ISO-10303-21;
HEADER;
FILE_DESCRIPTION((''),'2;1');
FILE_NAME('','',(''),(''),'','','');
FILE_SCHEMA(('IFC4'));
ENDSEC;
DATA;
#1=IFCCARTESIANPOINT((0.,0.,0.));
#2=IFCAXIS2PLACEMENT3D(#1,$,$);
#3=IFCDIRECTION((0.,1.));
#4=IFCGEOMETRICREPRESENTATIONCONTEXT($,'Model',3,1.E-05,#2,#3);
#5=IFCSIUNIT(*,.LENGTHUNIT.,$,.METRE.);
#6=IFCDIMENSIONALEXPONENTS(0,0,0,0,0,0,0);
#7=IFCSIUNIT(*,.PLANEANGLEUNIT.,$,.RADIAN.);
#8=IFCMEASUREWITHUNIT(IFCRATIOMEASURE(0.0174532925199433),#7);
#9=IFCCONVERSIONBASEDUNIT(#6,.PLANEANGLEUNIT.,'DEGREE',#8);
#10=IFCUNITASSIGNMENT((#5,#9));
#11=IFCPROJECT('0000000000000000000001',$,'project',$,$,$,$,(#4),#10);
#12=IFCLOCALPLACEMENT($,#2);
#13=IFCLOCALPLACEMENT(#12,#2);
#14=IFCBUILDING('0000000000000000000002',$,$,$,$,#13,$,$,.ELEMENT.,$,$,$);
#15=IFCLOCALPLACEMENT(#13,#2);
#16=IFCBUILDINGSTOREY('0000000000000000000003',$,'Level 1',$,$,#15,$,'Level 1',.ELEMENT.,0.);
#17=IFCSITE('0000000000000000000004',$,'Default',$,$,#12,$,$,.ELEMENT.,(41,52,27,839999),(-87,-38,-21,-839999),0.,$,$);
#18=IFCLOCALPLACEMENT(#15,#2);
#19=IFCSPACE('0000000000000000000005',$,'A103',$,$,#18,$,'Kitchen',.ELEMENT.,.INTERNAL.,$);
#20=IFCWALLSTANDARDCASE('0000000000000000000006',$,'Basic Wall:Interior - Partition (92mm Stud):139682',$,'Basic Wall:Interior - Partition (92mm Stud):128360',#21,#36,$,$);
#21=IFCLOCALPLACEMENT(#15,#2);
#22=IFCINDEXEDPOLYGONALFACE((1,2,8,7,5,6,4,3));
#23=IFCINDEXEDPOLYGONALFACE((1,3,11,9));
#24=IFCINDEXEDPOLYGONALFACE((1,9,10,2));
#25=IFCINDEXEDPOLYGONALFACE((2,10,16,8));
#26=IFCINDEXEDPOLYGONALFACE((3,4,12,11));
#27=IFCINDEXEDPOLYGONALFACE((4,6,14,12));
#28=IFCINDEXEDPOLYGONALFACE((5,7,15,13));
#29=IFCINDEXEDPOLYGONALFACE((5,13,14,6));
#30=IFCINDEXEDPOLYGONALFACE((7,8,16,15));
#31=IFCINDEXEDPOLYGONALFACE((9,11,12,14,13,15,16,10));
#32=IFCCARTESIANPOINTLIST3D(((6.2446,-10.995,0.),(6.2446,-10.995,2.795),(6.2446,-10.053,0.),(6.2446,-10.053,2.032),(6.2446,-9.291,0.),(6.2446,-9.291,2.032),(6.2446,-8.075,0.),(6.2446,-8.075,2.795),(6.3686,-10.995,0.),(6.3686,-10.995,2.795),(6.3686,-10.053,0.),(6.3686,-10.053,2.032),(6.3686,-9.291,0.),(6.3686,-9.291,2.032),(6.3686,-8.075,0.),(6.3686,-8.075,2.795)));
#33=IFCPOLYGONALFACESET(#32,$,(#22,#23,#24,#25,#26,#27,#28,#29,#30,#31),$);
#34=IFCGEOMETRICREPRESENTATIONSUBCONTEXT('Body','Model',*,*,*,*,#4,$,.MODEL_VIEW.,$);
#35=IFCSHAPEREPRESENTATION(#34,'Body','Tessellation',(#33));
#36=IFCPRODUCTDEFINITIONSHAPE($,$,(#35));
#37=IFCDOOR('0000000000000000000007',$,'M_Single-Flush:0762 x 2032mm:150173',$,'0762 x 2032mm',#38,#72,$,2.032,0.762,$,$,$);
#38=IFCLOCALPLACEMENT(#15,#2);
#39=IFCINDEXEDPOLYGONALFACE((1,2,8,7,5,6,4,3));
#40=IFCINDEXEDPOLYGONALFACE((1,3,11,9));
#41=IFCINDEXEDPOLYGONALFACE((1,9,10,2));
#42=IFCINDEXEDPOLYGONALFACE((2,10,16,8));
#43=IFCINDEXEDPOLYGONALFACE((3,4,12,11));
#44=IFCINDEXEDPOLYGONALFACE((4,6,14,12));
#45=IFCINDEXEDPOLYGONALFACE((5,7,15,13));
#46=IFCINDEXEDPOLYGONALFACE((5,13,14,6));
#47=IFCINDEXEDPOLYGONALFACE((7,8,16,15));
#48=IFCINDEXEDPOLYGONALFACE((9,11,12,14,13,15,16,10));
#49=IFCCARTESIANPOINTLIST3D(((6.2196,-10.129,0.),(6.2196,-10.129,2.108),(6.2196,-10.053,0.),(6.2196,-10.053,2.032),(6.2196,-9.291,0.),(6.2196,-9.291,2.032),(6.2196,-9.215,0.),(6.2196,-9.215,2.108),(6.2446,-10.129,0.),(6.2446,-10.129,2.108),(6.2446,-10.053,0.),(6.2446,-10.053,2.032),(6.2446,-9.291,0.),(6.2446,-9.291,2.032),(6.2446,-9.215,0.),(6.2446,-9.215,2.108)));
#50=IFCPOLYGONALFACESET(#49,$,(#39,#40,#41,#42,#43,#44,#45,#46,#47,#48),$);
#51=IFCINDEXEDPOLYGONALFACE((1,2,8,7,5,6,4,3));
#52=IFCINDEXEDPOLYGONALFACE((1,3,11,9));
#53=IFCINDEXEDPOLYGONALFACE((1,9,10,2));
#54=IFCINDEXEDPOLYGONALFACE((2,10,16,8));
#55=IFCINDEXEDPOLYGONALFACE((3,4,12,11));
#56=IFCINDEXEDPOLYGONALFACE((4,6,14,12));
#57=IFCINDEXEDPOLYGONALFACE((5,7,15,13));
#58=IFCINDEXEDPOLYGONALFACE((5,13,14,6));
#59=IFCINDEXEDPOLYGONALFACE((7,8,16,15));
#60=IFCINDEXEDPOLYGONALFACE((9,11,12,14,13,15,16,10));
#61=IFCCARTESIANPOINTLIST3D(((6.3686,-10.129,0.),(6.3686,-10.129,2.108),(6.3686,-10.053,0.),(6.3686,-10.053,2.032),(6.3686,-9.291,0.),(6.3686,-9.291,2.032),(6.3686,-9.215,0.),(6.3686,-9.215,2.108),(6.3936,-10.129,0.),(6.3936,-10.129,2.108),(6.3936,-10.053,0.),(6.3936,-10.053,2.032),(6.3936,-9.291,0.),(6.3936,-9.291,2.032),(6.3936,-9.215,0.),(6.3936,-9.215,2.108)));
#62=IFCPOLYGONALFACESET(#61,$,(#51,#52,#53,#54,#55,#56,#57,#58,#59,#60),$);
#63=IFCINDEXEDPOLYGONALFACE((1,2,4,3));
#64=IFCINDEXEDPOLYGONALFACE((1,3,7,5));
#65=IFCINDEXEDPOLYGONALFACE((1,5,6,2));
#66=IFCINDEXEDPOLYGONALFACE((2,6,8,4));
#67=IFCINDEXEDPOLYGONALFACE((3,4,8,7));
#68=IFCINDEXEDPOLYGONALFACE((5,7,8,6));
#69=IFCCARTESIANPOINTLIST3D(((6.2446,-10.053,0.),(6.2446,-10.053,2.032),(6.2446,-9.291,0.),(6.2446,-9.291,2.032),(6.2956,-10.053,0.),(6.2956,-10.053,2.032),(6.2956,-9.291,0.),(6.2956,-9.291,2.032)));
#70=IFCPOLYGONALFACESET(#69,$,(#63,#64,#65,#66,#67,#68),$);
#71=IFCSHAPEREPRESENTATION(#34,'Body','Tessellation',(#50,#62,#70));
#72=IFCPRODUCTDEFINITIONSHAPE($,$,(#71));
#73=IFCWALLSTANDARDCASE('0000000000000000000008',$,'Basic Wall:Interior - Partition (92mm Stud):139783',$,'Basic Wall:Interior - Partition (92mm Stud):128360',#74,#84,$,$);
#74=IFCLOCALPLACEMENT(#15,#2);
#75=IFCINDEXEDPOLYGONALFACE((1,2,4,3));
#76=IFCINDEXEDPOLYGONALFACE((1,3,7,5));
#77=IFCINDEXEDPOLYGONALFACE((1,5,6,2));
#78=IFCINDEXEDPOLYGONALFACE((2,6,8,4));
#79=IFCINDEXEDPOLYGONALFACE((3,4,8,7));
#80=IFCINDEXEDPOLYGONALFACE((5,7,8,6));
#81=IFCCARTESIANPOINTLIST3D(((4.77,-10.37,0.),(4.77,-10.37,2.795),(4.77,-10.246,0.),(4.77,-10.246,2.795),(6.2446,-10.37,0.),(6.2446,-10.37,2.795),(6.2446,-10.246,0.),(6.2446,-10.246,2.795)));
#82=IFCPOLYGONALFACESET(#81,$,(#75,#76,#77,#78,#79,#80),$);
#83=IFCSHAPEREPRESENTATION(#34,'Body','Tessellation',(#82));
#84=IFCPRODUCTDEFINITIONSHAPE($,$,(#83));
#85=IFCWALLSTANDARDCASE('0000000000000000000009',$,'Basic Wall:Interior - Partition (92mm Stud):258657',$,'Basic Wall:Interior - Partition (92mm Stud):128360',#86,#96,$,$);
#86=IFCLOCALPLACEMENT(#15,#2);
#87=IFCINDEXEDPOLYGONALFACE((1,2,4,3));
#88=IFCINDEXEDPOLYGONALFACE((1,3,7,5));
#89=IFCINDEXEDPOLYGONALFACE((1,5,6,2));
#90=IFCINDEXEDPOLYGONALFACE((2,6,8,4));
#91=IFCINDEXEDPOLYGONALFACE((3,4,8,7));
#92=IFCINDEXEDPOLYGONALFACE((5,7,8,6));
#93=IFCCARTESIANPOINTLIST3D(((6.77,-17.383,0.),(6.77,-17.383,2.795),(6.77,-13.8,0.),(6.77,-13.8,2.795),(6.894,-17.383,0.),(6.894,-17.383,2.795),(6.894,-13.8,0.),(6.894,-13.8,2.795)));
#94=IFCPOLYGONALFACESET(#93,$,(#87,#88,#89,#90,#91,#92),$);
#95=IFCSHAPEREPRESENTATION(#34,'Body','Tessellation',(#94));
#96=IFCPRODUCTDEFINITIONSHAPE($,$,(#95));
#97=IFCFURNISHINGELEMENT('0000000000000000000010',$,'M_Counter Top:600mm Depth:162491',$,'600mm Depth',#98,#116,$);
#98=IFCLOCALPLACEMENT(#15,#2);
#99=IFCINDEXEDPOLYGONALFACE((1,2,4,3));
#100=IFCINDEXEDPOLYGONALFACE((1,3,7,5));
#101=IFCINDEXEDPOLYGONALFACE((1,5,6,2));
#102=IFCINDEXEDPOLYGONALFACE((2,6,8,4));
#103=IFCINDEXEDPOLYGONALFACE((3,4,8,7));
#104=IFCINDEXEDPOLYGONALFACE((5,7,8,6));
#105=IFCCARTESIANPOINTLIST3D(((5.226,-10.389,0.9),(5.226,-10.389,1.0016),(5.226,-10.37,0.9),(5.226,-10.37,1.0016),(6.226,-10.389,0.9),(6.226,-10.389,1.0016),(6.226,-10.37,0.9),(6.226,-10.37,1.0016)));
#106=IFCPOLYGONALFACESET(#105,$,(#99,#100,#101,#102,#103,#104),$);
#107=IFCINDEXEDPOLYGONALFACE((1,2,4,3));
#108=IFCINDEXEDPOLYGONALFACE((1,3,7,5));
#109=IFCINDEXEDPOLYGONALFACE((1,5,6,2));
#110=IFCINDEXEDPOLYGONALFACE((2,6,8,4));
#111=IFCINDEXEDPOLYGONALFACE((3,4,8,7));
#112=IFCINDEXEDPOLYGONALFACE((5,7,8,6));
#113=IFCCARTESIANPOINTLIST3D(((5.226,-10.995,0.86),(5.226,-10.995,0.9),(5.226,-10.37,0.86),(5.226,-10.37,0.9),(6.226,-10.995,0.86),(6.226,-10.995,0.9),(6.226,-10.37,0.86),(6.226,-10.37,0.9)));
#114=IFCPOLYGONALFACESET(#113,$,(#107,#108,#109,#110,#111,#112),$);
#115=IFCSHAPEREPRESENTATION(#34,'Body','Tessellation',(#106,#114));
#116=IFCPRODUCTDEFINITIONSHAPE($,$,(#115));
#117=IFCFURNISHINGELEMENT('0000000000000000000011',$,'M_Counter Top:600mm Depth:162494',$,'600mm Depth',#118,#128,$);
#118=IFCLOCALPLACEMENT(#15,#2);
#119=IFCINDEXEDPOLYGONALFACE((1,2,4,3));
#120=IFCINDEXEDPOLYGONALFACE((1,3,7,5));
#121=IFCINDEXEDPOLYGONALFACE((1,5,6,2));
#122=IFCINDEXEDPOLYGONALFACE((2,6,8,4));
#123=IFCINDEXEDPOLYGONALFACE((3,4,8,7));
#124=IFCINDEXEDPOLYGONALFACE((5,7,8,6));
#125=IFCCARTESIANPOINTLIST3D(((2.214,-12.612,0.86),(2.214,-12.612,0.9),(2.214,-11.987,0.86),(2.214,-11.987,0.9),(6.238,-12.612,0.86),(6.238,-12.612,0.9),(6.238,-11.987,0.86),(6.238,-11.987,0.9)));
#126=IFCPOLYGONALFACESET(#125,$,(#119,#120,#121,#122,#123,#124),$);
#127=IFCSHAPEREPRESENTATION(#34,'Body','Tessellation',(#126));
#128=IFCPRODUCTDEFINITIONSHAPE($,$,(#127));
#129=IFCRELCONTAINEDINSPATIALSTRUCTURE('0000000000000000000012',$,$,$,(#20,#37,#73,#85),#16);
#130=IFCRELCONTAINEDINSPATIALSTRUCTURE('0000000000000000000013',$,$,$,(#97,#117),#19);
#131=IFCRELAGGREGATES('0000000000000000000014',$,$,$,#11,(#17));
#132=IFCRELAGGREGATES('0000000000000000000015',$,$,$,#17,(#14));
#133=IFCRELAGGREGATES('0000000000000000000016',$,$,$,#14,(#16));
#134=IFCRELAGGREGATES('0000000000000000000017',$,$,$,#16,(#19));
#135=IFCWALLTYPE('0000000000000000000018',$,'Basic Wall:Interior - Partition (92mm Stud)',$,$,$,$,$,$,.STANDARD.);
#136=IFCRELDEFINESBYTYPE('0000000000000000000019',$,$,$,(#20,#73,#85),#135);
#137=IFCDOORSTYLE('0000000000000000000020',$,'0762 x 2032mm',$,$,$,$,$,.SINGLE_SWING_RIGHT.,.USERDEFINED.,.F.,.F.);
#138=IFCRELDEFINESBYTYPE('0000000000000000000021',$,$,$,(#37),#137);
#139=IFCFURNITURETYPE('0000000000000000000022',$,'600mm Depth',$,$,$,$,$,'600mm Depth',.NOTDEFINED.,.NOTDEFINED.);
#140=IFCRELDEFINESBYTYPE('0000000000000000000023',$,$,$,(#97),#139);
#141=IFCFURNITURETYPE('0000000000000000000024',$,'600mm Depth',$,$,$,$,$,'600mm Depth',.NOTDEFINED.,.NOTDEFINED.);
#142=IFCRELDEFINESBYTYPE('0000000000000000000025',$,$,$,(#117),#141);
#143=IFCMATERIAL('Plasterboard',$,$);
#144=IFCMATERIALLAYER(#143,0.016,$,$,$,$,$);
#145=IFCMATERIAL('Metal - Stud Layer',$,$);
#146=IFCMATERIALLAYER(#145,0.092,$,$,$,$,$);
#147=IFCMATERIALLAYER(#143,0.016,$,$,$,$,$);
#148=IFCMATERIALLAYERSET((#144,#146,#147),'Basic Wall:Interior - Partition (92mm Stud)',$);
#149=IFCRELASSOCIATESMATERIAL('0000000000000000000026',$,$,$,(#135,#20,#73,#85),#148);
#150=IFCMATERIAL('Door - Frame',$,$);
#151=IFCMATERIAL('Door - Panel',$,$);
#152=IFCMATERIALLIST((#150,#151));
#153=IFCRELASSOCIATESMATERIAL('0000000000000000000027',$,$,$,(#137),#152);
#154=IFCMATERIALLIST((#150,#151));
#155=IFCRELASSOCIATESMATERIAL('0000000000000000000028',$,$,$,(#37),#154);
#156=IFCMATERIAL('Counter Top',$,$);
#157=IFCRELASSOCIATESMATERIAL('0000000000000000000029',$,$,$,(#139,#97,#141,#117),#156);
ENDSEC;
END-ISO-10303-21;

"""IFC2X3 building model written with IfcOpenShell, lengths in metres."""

from ifc_helpers import new_model, entity, si_unit, converted_unit, direction, frame, frame_2d, origin, origin_2d_with_axis, place, context, subcontext, project, spatial, polyline, rectangle, outline, extrude, source, transform, mapped, material, material_list, layer, layer_set, layer_usage, type_object, type_shapes, element, fill, save


model = new_model("IFC2X3")

# Units and contexts
model_context = context("Model", 3, precision=1e-05, world=origin(), true_north=direction((0.0, 1.0)))
body_context = subcontext(model_context, "Body", "Model", "MODEL_VIEW")
ifc_project = project(units=[si_unit("LENGTHUNIT", "METRE"), converted_unit("PLANEANGLEUNIT", "DEGREE", entity("IfcRatioMeasure", 0.0174532925199433), si_unit("PLANEANGLEUNIT", "RADIAN"), dimensions=[0, 0, 0, 0, 0, 0, 0])], contexts=[model_context])

# Site, building, storey
site_placement = place(None, origin())
site = spatial("IfcSite", under=ifc_project, at=site_placement, Name="Default", CompositionType="ELEMENT", RefLatitude=(41, 52, 27, 839999), RefLongitude=(-87, -38, -21, -839999), RefElevation=0.0)
building_placement = place(site_placement, origin())
building = spatial("IfcBuilding", under=site, at=building_placement, CompositionType="ELEMENT")
storey_placement = place(building_placement, origin())
storey = spatial("IfcBuildingStorey", under=building, at=storey_placement, Name="Level 1", LongName="Level 1", CompositionType="ELEMENT", Elevation=0.0)

# Shared definitions
ifc_material_1 = material(Name="Metal - Stud Layer")
ifc_material_2 = material(Name="Plasterboard")
ifc_material_3 = material(Name="Door - Frame")
ifc_material_4 = material(Name="Door - Panel")

# Wall, opening, door
ifc_layer_1 = layer(ifc_material_2, 0.016)
ifc_layer_2 = layer(ifc_material_1, 0.092)
ifc_layer_3 = layer(ifc_material_2, 0.016)
ifc_layer_set_1 = layer_set([ifc_layer_1, ifc_layer_2, ifc_layer_3], Name="Basic Wall:Interior - Partition (92mm Stud)")
ifc_layer_usage_1 = layer_usage(ifc_layer_set_1, "AXIS2", "NEGATIVE", 0.062)
wall_type_1 = type_object("IfcWallType", Name="Basic Wall:Interior - Partition (92mm Stud)", PredefinedType="STANDARD", material=ifc_layer_set_1)
wall_1_placement = place(storey_placement, frame((6.3066, -10.995, 0.0), z_axis=(0.0, 0.0, 1.0), x_axis=(0.0, 1.0, 0.0)))
wall_1 = element("IfcWallStandardCase", 1, at=wall_1_placement, inside=storey, type_object=wall_type_1, material=ifc_layer_usage_1, Name="Basic Wall:Interior - Partition (92mm Stud):139682", ObjectType="Basic Wall:Interior - Partition (92mm Stud):128360", context=body_context, shape_type="SweptSolid", body=[
    extrude(rectangle(XDim=2.92, YDim=0.124, at=frame_2d((1.46, 0.0), x_axis=(-1.0, 0.0))), origin(), (0.0, 0.0, 1.0), 2.795),
])
opening_1_placement = place(wall_1_placement, frame((0.942, -0.062, 0.0)))
opening_1 = element("IfcOpeningElement", 2, at=opening_1_placement, cuts=wall_1, ObjectType="Opening", context=body_context, shape_type="SweptSolid", body=[
    extrude(rectangle(XDim=0.762, YDim=2.032, at=frame_2d((1.016, 0.381), x_axis=(0.0, 1.0))), frame((0.0, 0.0, 0.0), z_axis=(0.0, 1.0, 0.0), x_axis=(0.0, 0.0, 1.0)), (0.0, 0.0, 1.0), 0.124),
])
ifc_material_list_1 = material_list([ifc_material_3, ifc_material_4])
ifc_material_list_2 = material_list([ifc_material_3, ifc_material_4])
door_style_1 = type_object("IfcDoorStyle", Name="0762 x 2032mm", ConstructionType="USERDEFINED", OperationType="SINGLE_SWING_RIGHT", ParameterTakesPrecedence=False, Sizeable=False, material=ifc_material_list_2)
shared_shape_1 = source(origin(), body_context, "Body", "SweptSolid", [
    extrude(outline(polyline([(-0.457, -1.073), (0.457, -1.073), (0.457, 1.035), (0.381, 1.035), (0.381, -0.997), (-0.381, -0.997), (-0.381, 1.035), (-0.457, 1.035), (-0.457, -1.073)])), frame((0.381, 0.124, 1.035), z_axis=(0.0, 1.0, 0.0), x_axis=(1.0, 0.0, 0.0)), (0.0, 0.0, 1.0), 0.025),
    extrude(outline(polyline([(-1.073, -0.457), (1.035, -0.457), (1.035, -0.381), (-0.997, -0.381), (-0.997, 0.381), (1.035, 0.381), (1.035, 0.457), (-1.073, 0.457), (-1.073, -0.457)])), frame((0.381, -0.025, 1.035), z_axis=(0.0, 1.0, 0.0), x_axis=(0.0, 0.0, -1.0)), (0.0, 0.0, 1.0), 0.025),
    extrude(rectangle(XDim=0.051, YDim=0.762, at=origin_2d_with_axis()), frame((0.381, 0.0985, 0.0), z_axis=(0.0, 0.0, 1.0), x_axis=(0.0, 1.0, 0.0)), (0.0, 0.0, 1.0), 2.032),
])
type_shapes(door_style_1, [shared_shape_1])
door_1_placement = place(opening_1_placement, origin())
door_1 = element("IfcDoor", 3, at=door_1_placement, inside=storey, type_object=door_style_1, material=ifc_material_list_1, Name="M_Single-Flush:0762 x 2032mm:150173", ObjectType="0762 x 2032mm", OverallHeight=2.032, OverallWidth=0.762, context=body_context, shape_type="MappedRepresentation", body=[
    mapped(shared_shape_1, transform((0.0, 0.0, 0.0), scale=1.0)),
])
fill(opening_1, door_1)

# Walls
ifc_layer_usage_2 = layer_usage(ifc_layer_set_1, "AXIS2", "NEGATIVE", 0.062)
wall_2_placement = place(storey_placement, frame((4.77, -10.308, 0.0)))
element("IfcWallStandardCase", 4, at=wall_2_placement, inside=storey, type_object=wall_type_1, material=ifc_layer_usage_2, Name="Basic Wall:Interior - Partition (92mm Stud):139783", ObjectType="Basic Wall:Interior - Partition (92mm Stud):128360", context=body_context, shape_type="SweptSolid", body=[
    extrude(rectangle(XDim=1.4746, YDim=0.124, at=frame_2d((0.7373, 0.0), x_axis=(-1.0, 0.0))), origin(), (0.0, 0.0, 1.0), 2.795),
])
ifc_layer_usage_3 = layer_usage(ifc_layer_set_1, "AXIS2", "NEGATIVE", 0.062)
wall_3_placement = place(storey_placement, frame((6.832, -13.8, 0.0), z_axis=(0.0, 0.0, 1.0), x_axis=(0.0, -1.0, 0.0)))
element("IfcWallStandardCase", 5, at=wall_3_placement, inside=storey, type_object=wall_type_1, material=ifc_layer_usage_3, Name="Basic Wall:Interior - Partition (92mm Stud):258657", ObjectType="Basic Wall:Interior - Partition (92mm Stud):128360", context=body_context, shape_type="SweptSolid", body=[
    extrude(rectangle(XDim=3.583, YDim=0.124, at=frame_2d((1.7915, 0.0), x_axis=(-1.0, 0.0))), origin(), (0.0, 0.0, 1.0), 2.795),
])

# Shared definitions
space_1_placement = place(storey_placement, origin())
space_1 = spatial("IfcSpace", under=storey, at=space_1_placement, Name="A103", LongName="Kitchen", CompositionType="ELEMENT", InteriorOrExteriorSpace="INTERNAL")

# Furnishing elements
ifc_material_5 = material(Name="Counter Top")
furniture_type_1 = type_object("IfcFurnitureType", Name="600mm Depth", ElementType="600mm Depth", material=ifc_material_5)
shared_shape_2 = source(origin(), body_context, "Body", "SweptSolid", [
    extrude(rectangle(XDim=0.0191, YDim=1.0, at=frame_2d((0.0, 0.0), x_axis=(1.0, 0.0))), frame((-0.7005, -0.0095, 0.9), z_axis=(0.0, 0.0, 1.0), x_axis=(0.0, -1.0, 0.0)), (0.0, 0.0, 1.0), 0.1016),
    extrude(rectangle(XDim=1.0, YDim=0.625, at=frame_2d((0.0, 0.0), x_axis=(1.0, 0.0))), frame((-0.7005, -0.3125, 0.86), z_axis=(0.0, 0.0, 1.0), x_axis=(-1.0, 0.0, 0.0)), (0.0, 0.0, 1.0), 0.04),
])
type_shapes(furniture_type_1, [shared_shape_2])
furnishing_1_placement = place(space_1_placement, frame((6.4265, -10.37, 0.0)))
element("IfcFurnishingElement", 6, at=furnishing_1_placement, inside=space_1, type_object=furniture_type_1, material=ifc_material_5, Name="M_Counter Top:600mm Depth:162491", ObjectType="600mm Depth", context=body_context, shape_type="MappedRepresentation", body=[
    mapped(shared_shape_2, transform((0.0, 0.0, 0.0), scale=1.0)),
])
furniture_type_2 = type_object("IfcFurnitureType", Name="600mm Depth", ElementType="600mm Depth", material=ifc_material_5)
shared_shape_3 = source(origin(), body_context, "Body", "SweptSolid", [
    extrude(rectangle(XDim=4.024, YDim=0.625, at=frame_2d((0.0, 0.0), x_axis=(1.0, 0.0))), frame((0.8115, -0.3125, 0.86), z_axis=(0.0, 0.0, 1.0), x_axis=(-1.0, 0.0, 0.0)), (0.0, 0.0, 1.0), 0.04),
])
type_shapes(furniture_type_2, [shared_shape_3])
furnishing_2_placement = place(space_1_placement, frame((5.0375, -12.612, 0.0), z_axis=(0.0, 0.0, 1.0), x_axis=(-1.0, 0.0, 0.0)))
element("IfcFurnishingElement", 7, at=furnishing_2_placement, inside=space_1, type_object=furniture_type_2, material=ifc_material_5, Name="M_Counter Top:600mm Depth:162494", ObjectType="600mm Depth", context=body_context, shape_type="MappedRepresentation", body=[
    mapped(shared_shape_3, transform((0.0, 0.0, 0.0), scale=1.0)),
])

save(model, "model.ifc")
